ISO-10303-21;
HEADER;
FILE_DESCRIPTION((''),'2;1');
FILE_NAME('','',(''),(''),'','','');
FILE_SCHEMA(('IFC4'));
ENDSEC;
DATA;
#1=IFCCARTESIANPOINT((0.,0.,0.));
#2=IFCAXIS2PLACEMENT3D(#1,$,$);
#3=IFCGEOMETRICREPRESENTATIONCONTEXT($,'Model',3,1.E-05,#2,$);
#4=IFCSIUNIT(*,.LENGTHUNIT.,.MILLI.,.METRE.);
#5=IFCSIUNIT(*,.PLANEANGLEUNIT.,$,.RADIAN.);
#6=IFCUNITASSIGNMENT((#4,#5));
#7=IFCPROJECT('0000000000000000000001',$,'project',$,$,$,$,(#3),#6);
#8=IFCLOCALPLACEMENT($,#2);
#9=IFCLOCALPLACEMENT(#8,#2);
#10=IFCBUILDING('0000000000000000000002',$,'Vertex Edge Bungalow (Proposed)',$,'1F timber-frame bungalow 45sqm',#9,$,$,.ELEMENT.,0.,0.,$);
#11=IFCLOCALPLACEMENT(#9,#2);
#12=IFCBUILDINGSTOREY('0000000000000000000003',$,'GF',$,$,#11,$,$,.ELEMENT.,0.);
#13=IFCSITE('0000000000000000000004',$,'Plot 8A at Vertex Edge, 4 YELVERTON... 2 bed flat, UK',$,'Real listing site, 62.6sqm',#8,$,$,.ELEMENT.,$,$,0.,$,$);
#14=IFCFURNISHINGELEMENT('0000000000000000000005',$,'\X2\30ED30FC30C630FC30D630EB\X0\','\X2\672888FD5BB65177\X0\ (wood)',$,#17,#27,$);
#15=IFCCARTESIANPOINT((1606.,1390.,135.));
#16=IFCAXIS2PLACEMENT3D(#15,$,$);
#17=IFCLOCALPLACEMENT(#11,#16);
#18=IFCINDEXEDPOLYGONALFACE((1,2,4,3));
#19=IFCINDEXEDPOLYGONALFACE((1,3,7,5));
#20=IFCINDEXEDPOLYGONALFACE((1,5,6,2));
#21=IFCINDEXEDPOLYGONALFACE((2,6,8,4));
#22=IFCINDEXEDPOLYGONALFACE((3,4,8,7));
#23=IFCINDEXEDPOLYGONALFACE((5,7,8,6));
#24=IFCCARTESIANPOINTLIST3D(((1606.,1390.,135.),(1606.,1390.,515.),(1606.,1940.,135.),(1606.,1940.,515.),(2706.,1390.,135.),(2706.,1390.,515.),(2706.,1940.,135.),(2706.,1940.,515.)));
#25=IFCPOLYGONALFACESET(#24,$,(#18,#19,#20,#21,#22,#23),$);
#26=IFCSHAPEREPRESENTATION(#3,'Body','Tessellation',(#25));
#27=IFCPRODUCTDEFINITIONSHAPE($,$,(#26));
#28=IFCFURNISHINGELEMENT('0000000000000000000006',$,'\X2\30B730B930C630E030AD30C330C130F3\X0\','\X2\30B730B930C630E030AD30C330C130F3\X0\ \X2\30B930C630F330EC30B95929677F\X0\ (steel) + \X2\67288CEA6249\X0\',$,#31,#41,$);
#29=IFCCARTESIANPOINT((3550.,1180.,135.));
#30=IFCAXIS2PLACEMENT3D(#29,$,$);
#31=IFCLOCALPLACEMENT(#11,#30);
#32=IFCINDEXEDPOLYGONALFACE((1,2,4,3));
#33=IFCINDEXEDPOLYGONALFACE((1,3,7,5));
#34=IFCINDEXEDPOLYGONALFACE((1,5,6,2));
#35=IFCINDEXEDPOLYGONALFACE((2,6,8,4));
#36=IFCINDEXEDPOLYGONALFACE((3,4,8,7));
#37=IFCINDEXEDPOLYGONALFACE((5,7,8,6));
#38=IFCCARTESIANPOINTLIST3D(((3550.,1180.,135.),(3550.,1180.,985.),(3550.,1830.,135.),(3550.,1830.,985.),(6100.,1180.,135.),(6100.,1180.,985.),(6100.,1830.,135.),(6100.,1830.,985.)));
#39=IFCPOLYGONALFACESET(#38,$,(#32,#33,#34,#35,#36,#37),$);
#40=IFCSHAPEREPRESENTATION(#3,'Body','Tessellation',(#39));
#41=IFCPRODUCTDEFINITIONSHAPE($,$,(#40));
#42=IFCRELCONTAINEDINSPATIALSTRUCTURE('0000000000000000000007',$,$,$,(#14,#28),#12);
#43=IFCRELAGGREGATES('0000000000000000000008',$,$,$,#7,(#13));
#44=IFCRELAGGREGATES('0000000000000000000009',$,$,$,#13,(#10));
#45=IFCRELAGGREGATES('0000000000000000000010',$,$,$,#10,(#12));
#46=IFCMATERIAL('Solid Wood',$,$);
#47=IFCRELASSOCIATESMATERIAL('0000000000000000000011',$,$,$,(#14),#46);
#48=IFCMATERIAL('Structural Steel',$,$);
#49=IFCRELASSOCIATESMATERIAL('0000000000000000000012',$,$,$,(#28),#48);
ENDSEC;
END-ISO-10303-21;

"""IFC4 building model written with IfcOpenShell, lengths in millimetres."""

from ifc_helpers import new_model, si_unit, frame, frame_2d, origin, place, context, project, spatial, rectangle, extrude, material, element, save


model = new_model("IFC4")

# Units and contexts
model_context = context("Model", 3, precision=1e-05, world=origin())
ifc_project = project(units=[si_unit("LENGTHUNIT", "METRE", prefix="MILLI"), si_unit("PLANEANGLEUNIT", "RADIAN")], contexts=[model_context])

# Site, building, storey
site_placement = place(None, origin())
site = spatial("IfcSite", under=ifc_project, at=site_placement, Name="Plot 8A at Vertex Edge, 4 YELVERTON... 2 bed flat, UK", ObjectType="Real listing site, 62.6sqm", CompositionType="ELEMENT", RefElevation=0.0)
building_placement = place(site_placement, origin())
building = spatial("IfcBuilding", under=site, at=building_placement, Name="Vertex Edge Bungalow (Proposed)", ObjectType="1F timber-frame bungalow 45sqm", CompositionType="ELEMENT", ElevationOfRefHeight=0.0, ElevationOfTerrain=0.0)
storey_placement = place(building_placement, origin())
storey = spatial("IfcBuildingStorey", under=building, at=storey_placement, Name="GF", CompositionType="ELEMENT", Elevation=0.0)

# Shared definitions
ifc_material_1 = material(Name="Solid Wood")

# Furnishing elements
furnishing_1_placement = place(storey_placement, frame((1606.0, 1390.0, 135.0)))
element("IfcFurnishingElement", 1, at=furnishing_1_placement, inside=storey, material=ifc_material_1, Name="ローテーブル", Description="木製家具 (wood)", context=model_context, shape_type="SweptSolid", body=[
    extrude(rectangle(XDim=1100.0, YDim=550.0, at=frame_2d((550.0, 275.0))), frame((1606.0, 1390.0, 135.0)), (0.0, 0.0, 1.0), 380.0),
])
ifc_material_2 = material(Name="Structural Steel")
furnishing_2_placement = place(storey_placement, frame((3550.0, 1180.0, 135.0)))
element("IfcFurnishingElement", 2, at=furnishing_2_placement, inside=storey, material=ifc_material_2, Name="システムキッチン", Description="システムキッチン ステンレス天板 (steel) + 木質扉", context=model_context, shape_type="SweptSolid", body=[
    extrude(rectangle(XDim=2550.0, YDim=650.0, at=frame_2d((1275.0, 325.0))), frame((3550.0, 1180.0, 135.0)), (0.0, 0.0, 1.0), 850.0),
])

save(model, "model.ifc")
